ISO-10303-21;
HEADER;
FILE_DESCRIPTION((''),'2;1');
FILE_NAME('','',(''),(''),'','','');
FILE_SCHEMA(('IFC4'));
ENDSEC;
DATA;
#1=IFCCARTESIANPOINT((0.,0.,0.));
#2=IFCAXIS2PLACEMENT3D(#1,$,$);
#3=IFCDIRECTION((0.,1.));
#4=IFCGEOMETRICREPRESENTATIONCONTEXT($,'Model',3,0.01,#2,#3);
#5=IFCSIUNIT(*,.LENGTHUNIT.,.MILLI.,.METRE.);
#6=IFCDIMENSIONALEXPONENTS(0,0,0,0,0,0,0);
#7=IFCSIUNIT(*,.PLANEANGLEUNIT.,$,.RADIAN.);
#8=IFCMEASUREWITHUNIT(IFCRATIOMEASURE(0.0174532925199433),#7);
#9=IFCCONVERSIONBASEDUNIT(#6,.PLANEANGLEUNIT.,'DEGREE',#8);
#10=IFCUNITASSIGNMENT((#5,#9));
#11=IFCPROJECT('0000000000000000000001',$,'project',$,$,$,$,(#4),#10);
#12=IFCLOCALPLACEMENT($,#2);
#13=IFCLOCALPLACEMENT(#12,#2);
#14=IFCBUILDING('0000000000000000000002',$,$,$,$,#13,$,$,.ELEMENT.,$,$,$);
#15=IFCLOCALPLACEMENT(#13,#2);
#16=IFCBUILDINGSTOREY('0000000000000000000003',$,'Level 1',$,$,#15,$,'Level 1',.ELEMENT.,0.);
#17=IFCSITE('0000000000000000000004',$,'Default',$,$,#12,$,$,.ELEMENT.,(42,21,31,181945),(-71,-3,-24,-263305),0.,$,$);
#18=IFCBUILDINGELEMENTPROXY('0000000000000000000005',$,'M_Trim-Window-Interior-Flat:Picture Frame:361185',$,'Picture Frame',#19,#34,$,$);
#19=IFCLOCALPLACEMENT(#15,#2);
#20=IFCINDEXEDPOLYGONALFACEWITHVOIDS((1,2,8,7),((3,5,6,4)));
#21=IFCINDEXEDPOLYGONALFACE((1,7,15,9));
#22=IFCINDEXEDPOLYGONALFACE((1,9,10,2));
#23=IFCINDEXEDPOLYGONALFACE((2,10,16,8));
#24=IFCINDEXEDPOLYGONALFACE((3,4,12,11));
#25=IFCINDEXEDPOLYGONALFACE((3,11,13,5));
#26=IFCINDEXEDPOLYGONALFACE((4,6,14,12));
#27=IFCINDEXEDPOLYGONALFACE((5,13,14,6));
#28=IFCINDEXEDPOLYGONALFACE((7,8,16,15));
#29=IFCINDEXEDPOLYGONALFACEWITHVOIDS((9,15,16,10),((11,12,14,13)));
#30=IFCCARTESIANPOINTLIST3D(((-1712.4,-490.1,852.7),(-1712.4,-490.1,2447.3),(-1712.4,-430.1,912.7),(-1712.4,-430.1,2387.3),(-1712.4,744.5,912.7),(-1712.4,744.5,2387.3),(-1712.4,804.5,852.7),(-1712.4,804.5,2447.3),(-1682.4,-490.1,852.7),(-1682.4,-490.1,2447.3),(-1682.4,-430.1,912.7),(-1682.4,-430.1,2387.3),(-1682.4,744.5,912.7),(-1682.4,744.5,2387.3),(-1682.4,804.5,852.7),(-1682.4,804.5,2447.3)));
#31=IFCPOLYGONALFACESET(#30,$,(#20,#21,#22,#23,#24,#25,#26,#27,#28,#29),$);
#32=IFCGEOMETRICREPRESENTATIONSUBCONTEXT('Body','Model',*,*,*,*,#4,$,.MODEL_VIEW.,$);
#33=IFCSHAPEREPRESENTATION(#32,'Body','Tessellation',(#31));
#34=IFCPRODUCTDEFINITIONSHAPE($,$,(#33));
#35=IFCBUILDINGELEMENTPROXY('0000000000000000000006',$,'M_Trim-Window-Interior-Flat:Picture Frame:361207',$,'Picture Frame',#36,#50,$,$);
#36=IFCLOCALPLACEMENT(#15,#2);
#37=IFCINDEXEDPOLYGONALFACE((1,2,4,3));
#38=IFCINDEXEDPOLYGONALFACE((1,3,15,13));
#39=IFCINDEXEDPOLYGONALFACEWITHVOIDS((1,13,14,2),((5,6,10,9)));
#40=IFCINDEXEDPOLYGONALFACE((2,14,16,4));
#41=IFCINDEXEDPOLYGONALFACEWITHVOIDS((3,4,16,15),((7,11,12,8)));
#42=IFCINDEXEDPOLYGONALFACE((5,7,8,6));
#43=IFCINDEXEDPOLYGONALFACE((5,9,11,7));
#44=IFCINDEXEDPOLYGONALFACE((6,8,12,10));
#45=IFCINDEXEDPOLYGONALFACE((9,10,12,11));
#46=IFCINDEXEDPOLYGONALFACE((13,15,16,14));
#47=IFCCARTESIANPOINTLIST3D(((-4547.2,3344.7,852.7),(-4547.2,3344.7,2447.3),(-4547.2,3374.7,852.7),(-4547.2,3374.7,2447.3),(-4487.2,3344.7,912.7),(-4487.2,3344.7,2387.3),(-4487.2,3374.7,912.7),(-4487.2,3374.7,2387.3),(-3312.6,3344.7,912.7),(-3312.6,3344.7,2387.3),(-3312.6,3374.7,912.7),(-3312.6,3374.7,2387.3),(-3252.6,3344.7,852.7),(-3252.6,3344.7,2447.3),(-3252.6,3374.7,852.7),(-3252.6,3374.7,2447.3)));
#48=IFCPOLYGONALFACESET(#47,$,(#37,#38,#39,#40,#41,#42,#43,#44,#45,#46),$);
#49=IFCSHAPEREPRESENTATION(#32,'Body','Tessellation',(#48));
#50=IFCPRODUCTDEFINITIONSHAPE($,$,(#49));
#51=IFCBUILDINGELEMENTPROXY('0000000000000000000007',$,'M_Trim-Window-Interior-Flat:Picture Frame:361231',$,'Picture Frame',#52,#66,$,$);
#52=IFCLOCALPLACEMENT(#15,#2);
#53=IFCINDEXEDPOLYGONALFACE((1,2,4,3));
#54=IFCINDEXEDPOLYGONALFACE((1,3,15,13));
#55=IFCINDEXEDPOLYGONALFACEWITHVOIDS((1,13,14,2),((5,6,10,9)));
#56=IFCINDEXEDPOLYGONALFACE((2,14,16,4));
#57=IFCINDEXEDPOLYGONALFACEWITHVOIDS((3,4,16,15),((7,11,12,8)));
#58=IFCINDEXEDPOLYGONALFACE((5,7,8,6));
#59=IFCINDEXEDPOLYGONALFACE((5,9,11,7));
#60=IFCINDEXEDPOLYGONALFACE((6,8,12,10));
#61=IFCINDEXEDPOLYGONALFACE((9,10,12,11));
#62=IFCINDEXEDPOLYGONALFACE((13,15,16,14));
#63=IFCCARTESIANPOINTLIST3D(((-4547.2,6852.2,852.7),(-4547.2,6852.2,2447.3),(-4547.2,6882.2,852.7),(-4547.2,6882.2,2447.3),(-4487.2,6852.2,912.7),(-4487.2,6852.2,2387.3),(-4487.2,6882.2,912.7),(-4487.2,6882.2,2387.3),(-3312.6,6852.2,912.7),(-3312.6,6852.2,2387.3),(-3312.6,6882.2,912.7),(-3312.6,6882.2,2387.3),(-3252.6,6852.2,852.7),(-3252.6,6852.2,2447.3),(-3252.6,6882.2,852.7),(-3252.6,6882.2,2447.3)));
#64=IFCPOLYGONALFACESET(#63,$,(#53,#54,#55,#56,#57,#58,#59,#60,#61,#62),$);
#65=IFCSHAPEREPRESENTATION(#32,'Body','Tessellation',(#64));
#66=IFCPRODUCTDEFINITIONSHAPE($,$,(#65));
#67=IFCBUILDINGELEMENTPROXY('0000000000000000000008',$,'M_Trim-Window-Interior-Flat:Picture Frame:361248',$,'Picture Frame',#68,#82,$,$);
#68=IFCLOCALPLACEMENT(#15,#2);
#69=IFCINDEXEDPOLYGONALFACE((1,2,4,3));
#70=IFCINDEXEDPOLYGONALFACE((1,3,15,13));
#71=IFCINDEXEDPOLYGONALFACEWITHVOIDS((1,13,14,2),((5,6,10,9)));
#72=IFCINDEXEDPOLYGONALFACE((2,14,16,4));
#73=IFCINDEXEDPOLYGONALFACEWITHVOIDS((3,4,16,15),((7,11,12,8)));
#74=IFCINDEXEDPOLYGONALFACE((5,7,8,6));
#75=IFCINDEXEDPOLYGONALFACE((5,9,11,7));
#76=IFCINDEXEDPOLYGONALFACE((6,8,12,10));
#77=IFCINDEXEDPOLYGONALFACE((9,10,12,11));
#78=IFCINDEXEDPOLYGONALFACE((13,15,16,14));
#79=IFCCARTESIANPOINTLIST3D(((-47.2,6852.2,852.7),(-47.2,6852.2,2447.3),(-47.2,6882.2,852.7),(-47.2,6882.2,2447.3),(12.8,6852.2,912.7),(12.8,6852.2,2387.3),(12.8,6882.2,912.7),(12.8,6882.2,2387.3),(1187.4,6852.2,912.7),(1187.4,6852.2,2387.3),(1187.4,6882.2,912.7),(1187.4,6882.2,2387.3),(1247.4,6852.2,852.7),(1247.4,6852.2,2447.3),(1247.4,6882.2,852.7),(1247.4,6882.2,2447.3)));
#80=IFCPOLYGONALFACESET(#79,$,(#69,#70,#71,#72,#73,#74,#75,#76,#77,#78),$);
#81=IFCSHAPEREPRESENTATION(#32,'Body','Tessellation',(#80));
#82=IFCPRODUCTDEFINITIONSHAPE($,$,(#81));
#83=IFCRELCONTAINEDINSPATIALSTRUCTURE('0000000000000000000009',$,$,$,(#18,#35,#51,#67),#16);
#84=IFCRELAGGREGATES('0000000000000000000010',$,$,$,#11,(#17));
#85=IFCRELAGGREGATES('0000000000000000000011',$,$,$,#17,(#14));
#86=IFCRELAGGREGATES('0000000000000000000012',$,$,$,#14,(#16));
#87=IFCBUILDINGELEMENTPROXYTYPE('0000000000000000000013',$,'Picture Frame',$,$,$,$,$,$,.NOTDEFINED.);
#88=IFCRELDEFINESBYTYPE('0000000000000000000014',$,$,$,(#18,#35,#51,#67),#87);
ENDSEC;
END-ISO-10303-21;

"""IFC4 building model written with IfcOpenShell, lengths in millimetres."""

from ifc_helpers import new_model, entity, si_unit, converted_unit, direction, frame, origin, place, context, subcontext, project, spatial, polyline, outline, extrude, source, transform, mapped, type_object, type_shapes, element, save


model = new_model("IFC4")

# Units and contexts
model_context = context("Model", 3, precision=0.01, world=origin(), true_north=direction((0.0, 1.0)))
body_context = subcontext(model_context, "Body", "Model", "MODEL_VIEW")
ifc_project = project(units=[si_unit("LENGTHUNIT", "METRE", prefix="MILLI"), converted_unit("PLANEANGLEUNIT", "DEGREE", entity("IfcRatioMeasure", 0.0174532925199433), si_unit("PLANEANGLEUNIT", "RADIAN"), dimensions=[0, 0, 0, 0, 0, 0, 0])], contexts=[model_context])

# Site, building, storey
site_placement = place(None, origin())
site = spatial("IfcSite", under=ifc_project, at=site_placement, Name="Default", CompositionType="ELEMENT", RefLatitude=(42, 21, 31, 181945), RefLongitude=(-71, -3, -24, -263305), RefElevation=0.0)
building_placement = place(site_placement, origin())
building = spatial("IfcBuilding", under=site, at=building_placement, CompositionType="ELEMENT")
storey_placement = place(building_placement, origin())
storey = spatial("IfcBuildingStorey", under=building, at=storey_placement, Name="Level 1", LongName="Level 1", CompositionType="ELEMENT", Elevation=0.0)

# Building element proxies
building_element_proxy_type_1 = type_object("IfcBuildingElementProxyType", Name="Picture Frame", PredefinedType="NOTDEFINED")
shared_shape_1 = source(origin(), body_context, "Body", "SweptSolid", [
    extrude(outline(polyline([(-647.3, -797.3), (647.3, -797.3), (647.3, 797.3), (-647.3, 797.3), (-647.3, -797.3)]), holes=[polyline([(-587.3, -737.3), (-587.3, 737.3), (587.3, 737.3), (587.3, -737.3), (-587.3, -737.3)])]), frame((0.0, -750.0, 0.0), z_axis=(0.0, 0.0, 1.0), x_axis=(-1.0, 0.0, 0.0)), (0.0, 0.0, 1.0), 30.0),
])
type_shapes(building_element_proxy_type_1, [shared_shape_1])
for number, where, z_axis, x_axis, name in (
    (1, (-1712.4, 157.2, 2400.0), (1.0, 0.0, 0.0), (0.0, 1.0, 0.0), "M_Trim-Window-Interior-Flat:Picture Frame:361185"),
    (2, (-3899.9, 3344.7, 2400.0), (0.0, 1.0, 0.0), (-1.0, 0.0, 0.0), "M_Trim-Window-Interior-Flat:Picture Frame:361207"),
    (3, (-3899.9, 6882.2, 2400.0), (0.0, -1.0, 0.0), (1.0, 0.0, 0.0), "M_Trim-Window-Interior-Flat:Picture Frame:361231"),
    (4, (600.1, 6882.2, 2400.0), (0.0, -1.0, 0.0), (1.0, 0.0, 0.0), "M_Trim-Window-Interior-Flat:Picture Frame:361248"),
):
    element("IfcBuildingElementProxy", number, at=place(storey_placement, frame(where, z_axis=z_axis, x_axis=x_axis)), inside=storey, type_object=building_element_proxy_type_1, Name=name, ObjectType="Picture Frame", context=body_context, shape_type="MappedRepresentation", body=[
        mapped(shared_shape_1, transform((0.0, 0.0, 0.0), scale=1.0)),
    ])

save(model, "model.ifc")
